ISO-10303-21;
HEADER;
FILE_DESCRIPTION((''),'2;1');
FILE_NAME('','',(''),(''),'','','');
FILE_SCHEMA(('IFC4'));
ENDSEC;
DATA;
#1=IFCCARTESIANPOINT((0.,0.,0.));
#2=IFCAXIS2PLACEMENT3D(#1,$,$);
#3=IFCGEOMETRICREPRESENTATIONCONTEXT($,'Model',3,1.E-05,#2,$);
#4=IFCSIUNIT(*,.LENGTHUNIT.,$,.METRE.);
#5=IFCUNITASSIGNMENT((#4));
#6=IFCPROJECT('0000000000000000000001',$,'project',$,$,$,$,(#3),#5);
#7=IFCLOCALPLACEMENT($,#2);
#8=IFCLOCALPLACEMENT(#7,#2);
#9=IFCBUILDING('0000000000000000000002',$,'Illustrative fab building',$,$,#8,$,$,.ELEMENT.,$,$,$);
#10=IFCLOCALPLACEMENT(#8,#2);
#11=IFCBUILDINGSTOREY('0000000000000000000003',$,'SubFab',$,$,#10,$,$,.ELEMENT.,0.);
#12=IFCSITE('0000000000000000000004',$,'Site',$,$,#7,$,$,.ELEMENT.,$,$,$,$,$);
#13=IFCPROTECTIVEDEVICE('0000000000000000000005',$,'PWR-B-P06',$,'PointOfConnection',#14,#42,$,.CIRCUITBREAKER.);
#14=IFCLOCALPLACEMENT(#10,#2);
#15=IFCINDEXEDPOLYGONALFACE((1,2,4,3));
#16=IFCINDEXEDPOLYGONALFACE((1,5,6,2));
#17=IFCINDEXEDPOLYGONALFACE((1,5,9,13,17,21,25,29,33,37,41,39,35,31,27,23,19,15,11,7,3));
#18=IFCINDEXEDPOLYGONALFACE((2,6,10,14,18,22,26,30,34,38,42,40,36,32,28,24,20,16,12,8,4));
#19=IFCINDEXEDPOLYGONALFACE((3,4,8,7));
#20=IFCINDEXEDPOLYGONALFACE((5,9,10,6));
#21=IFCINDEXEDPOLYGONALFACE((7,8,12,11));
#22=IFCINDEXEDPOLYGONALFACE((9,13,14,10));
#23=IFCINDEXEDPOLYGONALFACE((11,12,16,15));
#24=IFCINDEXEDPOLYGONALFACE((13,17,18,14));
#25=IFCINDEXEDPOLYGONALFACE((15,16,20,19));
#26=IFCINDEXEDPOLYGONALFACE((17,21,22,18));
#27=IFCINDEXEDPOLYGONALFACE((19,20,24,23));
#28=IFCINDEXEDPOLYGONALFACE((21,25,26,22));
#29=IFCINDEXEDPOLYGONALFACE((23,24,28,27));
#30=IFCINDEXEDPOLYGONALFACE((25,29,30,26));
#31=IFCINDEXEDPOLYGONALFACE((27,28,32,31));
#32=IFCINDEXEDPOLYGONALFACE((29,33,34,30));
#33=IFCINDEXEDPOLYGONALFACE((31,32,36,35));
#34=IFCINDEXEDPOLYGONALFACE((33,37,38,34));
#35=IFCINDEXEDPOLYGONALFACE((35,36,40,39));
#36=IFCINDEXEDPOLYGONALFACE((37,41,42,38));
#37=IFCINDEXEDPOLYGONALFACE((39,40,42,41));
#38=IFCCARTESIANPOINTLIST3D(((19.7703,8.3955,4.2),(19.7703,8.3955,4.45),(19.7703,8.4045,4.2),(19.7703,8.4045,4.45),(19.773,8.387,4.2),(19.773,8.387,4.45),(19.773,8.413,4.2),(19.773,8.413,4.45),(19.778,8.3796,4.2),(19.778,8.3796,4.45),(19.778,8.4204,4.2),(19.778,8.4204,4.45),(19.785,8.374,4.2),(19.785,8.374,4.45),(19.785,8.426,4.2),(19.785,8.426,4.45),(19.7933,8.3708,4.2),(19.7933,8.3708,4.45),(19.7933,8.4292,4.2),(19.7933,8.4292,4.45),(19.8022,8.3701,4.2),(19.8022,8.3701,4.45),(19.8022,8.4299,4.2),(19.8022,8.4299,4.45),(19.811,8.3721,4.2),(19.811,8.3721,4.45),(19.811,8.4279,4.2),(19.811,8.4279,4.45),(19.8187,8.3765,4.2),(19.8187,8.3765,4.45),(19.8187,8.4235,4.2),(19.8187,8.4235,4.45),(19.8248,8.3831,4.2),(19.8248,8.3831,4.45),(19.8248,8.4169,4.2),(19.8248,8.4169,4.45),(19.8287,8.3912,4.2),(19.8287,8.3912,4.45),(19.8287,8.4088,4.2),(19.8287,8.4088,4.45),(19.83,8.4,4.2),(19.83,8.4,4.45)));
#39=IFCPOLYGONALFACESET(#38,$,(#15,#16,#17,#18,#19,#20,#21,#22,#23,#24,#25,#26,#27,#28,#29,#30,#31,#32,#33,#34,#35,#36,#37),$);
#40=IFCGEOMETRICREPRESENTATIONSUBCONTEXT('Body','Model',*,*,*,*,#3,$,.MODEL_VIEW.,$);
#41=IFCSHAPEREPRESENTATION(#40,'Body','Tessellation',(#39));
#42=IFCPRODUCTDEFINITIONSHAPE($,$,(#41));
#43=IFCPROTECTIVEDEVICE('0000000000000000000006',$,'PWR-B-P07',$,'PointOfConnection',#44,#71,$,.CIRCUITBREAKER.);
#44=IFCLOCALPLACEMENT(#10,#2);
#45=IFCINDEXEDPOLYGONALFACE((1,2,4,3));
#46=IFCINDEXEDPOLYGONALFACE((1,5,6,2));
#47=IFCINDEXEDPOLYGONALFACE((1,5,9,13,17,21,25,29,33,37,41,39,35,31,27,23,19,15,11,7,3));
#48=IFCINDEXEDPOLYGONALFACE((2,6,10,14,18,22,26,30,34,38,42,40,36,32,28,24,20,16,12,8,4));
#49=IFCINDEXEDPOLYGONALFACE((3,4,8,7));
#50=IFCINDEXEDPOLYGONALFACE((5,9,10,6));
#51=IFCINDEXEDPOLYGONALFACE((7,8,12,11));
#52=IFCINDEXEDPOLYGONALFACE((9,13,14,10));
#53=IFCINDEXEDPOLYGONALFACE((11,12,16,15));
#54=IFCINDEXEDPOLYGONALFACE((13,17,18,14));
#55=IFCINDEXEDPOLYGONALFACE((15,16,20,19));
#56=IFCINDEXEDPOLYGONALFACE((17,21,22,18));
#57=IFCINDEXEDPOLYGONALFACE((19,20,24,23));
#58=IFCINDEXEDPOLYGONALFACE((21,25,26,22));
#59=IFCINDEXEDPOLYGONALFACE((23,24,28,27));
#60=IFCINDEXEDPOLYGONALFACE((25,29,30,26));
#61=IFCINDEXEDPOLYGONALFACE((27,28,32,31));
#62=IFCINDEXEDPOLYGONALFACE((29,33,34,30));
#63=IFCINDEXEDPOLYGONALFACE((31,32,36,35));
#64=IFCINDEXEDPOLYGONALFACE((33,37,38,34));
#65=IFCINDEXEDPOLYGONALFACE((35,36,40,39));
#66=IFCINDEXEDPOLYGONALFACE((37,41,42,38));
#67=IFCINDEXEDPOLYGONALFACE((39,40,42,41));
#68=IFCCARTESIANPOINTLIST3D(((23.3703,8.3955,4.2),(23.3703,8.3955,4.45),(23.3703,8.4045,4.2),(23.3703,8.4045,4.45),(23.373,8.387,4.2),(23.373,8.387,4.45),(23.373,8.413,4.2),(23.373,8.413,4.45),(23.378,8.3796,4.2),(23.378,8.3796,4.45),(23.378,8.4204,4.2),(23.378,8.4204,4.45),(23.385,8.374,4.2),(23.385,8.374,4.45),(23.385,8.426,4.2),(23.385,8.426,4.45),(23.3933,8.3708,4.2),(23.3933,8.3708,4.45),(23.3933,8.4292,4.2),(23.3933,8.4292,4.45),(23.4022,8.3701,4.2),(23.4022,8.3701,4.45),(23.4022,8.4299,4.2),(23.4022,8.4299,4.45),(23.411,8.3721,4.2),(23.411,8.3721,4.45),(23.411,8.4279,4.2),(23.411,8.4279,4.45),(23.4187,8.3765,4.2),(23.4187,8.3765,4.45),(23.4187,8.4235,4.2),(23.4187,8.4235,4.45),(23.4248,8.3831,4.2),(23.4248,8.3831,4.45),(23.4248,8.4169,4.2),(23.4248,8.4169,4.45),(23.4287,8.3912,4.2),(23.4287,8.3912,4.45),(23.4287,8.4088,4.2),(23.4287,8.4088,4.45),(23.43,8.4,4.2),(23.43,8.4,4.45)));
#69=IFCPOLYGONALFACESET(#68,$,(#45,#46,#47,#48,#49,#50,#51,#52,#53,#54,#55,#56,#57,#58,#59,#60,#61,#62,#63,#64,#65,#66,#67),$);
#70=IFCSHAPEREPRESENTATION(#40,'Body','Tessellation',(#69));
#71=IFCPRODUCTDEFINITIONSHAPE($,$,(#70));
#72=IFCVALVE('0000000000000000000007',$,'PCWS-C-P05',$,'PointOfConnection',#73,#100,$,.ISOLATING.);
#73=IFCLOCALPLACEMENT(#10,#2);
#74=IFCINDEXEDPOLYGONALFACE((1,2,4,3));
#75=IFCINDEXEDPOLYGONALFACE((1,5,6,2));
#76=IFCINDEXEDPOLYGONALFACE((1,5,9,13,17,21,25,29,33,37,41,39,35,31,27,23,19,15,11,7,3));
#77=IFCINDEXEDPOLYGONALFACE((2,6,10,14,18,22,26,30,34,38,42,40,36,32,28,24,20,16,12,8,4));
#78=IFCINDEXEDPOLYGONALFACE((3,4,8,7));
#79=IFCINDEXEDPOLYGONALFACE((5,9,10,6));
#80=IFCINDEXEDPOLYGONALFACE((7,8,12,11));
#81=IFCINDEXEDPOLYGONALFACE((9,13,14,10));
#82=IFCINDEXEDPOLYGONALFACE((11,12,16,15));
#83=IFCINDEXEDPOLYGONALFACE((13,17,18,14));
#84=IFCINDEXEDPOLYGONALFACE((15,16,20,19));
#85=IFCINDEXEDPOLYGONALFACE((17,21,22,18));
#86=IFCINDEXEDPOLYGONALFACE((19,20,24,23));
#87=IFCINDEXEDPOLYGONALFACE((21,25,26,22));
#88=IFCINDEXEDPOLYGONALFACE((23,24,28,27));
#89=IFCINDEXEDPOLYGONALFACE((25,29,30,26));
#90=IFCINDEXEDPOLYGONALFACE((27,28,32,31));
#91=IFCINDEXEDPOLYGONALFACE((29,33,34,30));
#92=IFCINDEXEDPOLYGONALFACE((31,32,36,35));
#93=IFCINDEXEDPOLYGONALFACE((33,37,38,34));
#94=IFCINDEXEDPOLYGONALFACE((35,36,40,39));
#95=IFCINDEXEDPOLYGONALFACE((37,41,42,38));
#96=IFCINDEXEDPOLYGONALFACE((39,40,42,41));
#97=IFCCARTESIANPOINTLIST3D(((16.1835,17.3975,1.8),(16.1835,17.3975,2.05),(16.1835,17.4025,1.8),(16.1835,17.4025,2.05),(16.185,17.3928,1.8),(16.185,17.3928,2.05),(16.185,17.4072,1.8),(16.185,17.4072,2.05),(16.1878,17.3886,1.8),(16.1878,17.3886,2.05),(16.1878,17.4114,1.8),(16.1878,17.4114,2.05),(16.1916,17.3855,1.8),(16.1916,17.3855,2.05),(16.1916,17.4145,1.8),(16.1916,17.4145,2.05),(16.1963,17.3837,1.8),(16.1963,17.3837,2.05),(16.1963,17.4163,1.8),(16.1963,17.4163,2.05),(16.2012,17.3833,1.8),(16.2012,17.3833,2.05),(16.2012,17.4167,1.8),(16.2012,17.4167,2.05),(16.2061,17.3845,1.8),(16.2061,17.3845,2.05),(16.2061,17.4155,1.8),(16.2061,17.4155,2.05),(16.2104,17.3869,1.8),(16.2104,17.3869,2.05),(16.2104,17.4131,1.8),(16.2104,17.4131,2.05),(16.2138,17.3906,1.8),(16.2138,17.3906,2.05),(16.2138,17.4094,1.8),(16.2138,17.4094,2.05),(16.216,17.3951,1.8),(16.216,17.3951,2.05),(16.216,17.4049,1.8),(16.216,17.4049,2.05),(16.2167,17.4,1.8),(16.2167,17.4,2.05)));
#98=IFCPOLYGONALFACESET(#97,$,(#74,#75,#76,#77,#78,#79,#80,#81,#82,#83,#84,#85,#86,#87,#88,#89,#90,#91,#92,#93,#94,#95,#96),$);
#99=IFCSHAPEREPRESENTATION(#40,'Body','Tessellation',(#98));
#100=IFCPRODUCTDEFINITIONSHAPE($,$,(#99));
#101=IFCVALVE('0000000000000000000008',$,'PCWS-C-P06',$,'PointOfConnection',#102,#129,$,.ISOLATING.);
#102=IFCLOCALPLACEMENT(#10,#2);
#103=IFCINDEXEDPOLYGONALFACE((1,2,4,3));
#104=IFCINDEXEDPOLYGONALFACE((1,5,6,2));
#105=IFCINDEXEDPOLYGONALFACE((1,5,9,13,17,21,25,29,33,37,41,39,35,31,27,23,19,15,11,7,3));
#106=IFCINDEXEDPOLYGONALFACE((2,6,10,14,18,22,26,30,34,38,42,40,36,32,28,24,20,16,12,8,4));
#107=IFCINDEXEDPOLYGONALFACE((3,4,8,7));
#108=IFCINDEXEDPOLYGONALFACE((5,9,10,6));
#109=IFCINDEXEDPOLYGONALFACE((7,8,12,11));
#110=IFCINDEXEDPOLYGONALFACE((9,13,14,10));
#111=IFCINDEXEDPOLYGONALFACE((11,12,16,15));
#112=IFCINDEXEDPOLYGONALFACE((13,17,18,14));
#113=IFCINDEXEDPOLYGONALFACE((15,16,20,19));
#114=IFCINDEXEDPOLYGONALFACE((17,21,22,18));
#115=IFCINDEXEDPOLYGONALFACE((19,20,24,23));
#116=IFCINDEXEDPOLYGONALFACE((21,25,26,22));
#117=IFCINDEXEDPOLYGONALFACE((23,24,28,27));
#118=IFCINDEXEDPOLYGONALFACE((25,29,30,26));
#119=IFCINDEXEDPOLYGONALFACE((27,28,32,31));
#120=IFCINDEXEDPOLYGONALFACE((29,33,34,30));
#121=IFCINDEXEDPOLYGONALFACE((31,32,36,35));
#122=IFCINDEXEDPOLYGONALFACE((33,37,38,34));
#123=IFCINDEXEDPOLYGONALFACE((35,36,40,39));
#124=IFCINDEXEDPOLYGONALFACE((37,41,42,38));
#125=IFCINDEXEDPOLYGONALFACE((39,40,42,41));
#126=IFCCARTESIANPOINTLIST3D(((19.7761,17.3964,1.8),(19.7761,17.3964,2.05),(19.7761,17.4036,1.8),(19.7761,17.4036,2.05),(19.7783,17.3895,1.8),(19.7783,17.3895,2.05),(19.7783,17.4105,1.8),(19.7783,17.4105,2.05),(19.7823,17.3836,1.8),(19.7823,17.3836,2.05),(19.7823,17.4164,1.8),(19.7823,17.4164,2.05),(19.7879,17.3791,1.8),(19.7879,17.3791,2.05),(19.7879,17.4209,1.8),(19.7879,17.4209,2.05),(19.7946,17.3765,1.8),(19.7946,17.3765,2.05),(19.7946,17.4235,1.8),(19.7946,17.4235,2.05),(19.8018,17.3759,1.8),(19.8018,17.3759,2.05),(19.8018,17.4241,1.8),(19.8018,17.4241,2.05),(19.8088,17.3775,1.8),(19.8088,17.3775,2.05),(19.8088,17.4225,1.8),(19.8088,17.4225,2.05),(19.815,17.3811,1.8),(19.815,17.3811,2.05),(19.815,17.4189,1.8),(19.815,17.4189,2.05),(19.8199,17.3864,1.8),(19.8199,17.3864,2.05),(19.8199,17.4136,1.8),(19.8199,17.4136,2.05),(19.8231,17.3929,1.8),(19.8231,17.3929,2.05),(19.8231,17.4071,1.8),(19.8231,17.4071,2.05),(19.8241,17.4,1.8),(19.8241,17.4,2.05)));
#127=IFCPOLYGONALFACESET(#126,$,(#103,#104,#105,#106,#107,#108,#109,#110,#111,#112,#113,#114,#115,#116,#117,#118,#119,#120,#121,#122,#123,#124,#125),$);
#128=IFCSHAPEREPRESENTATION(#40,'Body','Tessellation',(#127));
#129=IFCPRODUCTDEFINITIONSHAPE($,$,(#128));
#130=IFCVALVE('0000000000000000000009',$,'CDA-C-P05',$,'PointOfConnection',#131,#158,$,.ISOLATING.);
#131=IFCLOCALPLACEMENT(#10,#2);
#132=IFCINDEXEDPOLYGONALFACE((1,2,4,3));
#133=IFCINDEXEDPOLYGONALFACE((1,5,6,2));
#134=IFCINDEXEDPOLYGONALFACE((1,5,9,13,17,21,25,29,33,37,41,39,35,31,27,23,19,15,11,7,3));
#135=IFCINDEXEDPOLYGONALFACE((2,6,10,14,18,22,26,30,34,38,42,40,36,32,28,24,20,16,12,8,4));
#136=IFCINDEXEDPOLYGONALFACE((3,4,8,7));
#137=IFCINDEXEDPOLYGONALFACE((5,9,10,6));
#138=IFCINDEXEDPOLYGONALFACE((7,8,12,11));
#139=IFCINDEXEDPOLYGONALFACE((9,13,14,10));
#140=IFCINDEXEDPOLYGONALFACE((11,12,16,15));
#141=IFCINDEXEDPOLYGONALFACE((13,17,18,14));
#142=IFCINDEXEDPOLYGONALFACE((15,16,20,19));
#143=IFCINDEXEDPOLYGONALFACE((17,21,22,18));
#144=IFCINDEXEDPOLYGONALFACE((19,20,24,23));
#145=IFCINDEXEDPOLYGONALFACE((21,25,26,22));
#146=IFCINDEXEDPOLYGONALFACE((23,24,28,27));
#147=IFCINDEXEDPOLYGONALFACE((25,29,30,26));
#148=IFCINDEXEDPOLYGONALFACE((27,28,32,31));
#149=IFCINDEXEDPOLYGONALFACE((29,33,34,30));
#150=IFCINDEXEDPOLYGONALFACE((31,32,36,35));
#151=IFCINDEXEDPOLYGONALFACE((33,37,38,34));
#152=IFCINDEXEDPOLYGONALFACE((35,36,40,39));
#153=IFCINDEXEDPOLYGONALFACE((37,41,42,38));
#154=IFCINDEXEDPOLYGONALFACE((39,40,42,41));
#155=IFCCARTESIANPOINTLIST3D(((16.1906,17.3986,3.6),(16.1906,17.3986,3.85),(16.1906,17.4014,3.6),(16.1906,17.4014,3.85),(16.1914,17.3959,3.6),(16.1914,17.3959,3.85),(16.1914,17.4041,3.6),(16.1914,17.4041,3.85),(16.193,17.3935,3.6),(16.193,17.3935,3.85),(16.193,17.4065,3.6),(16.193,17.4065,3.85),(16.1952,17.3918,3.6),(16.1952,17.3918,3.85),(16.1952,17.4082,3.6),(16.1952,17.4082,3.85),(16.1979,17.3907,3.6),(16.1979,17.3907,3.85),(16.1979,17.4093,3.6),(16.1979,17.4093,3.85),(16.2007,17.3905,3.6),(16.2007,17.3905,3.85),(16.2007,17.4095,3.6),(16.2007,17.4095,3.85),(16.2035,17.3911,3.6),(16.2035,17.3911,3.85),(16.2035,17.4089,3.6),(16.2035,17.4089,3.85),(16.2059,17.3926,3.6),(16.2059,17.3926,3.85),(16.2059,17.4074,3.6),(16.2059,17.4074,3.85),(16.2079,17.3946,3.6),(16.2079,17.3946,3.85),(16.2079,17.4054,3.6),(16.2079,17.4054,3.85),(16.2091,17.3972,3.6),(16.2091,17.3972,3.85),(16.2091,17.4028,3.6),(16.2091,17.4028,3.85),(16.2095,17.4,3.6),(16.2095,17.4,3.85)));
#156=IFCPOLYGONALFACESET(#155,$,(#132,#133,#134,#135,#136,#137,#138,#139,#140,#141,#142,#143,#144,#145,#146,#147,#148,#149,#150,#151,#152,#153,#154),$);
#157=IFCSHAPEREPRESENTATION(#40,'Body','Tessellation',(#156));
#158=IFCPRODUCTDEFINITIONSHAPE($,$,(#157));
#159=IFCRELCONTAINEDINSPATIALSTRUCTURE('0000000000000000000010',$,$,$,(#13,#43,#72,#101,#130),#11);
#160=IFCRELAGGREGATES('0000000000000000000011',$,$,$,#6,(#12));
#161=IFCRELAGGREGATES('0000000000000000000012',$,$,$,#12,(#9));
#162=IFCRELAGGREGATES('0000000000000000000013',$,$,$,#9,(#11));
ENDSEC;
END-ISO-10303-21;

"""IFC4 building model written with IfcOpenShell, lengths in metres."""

from ifc_helpers import new_model, entity, si_unit, frame, origin, place, context, subcontext, project, spatial, element, save


model = new_model("IFC4")

# Units and contexts
model_context = context("Model", 3, precision=1e-05, world=origin())
body_context = subcontext(model_context, "Body", "Model", "MODEL_VIEW")
ifc_project = project(units=[si_unit("LENGTHUNIT", "METRE")], contexts=[model_context])

# Site, building, storey
site_placement = place(None, origin())
site = spatial("IfcSite", under=ifc_project, at=site_placement, Name="Site", CompositionType="ELEMENT")
building_placement = place(site_placement, origin())
building = spatial("IfcBuilding", under=site, at=building_placement, Name="Illustrative fab building", CompositionType="ELEMENT")
storey_placement = place(building_placement, origin())
storey = spatial("IfcBuildingStorey", under=building, at=storey_placement, Name="SubFab", CompositionType="ELEMENT", Elevation=0.0)

# Protective devices
for number, where, name in (
    (1, (19.8, 8.4, 4.2), "PWR-B-P06"),
    (2, (23.4, 8.4, 4.2), "PWR-B-P07"),
):
    element("IfcProtectiveDevice", number, at=place(storey_placement, frame(where)), inside=storey, Name=name, ObjectType="PointOfConnection", PredefinedType="CIRCUITBREAKER", context=body_context, shape_type="AdvancedSweptSolid", body=[
        entity("IfcSweptDiskSolid", entity("IfcPolyline", [entity("IfcCartesianPoint", [0.0, 0.0, 0.0]), entity("IfcCartesianPoint", [0.0, 0.0, 0.25])]), 0.03),
    ])

# Valves
valve_1_placement = place(storey_placement, frame((16.2, 17.4, 1.8)))
element("IfcValve", 3, at=valve_1_placement, inside=storey, Name="PCWS-C-P05", ObjectType="PointOfConnection", PredefinedType="ISOLATING", context=body_context, shape_type="AdvancedSweptSolid", body=[
    entity("IfcSweptDiskSolid", entity("IfcPolyline", [entity("IfcCartesianPoint", [0.0, 0.0, 0.0]), entity("IfcCartesianPoint", [0.0, 0.0, 0.25])]), 0.0167),
])
valve_2_placement = place(storey_placement, frame((19.8, 17.4, 1.8)))
element("IfcValve", 4, at=valve_2_placement, inside=storey, Name="PCWS-C-P06", ObjectType="PointOfConnection", PredefinedType="ISOLATING", context=body_context, shape_type="AdvancedSweptSolid", body=[
    entity("IfcSweptDiskSolid", entity("IfcPolyline", [entity("IfcCartesianPoint", [0.0, 0.0, 0.0]), entity("IfcCartesianPoint", [0.0, 0.0, 0.25])]), 0.0241),
])
valve_3_placement = place(storey_placement, frame((16.2, 17.4, 3.6)))
element("IfcValve", 5, at=valve_3_placement, inside=storey, Name="CDA-C-P05", ObjectType="PointOfConnection", PredefinedType="ISOLATING", context=body_context, shape_type="AdvancedSweptSolid", body=[
    entity("IfcSweptDiskSolid", entity("IfcPolyline", [entity("IfcCartesianPoint", [0.0, 0.0, 0.0]), entity("IfcCartesianPoint", [0.0, 0.0, 0.25])]), 0.0095),
])

save(model, "model.ifc")
